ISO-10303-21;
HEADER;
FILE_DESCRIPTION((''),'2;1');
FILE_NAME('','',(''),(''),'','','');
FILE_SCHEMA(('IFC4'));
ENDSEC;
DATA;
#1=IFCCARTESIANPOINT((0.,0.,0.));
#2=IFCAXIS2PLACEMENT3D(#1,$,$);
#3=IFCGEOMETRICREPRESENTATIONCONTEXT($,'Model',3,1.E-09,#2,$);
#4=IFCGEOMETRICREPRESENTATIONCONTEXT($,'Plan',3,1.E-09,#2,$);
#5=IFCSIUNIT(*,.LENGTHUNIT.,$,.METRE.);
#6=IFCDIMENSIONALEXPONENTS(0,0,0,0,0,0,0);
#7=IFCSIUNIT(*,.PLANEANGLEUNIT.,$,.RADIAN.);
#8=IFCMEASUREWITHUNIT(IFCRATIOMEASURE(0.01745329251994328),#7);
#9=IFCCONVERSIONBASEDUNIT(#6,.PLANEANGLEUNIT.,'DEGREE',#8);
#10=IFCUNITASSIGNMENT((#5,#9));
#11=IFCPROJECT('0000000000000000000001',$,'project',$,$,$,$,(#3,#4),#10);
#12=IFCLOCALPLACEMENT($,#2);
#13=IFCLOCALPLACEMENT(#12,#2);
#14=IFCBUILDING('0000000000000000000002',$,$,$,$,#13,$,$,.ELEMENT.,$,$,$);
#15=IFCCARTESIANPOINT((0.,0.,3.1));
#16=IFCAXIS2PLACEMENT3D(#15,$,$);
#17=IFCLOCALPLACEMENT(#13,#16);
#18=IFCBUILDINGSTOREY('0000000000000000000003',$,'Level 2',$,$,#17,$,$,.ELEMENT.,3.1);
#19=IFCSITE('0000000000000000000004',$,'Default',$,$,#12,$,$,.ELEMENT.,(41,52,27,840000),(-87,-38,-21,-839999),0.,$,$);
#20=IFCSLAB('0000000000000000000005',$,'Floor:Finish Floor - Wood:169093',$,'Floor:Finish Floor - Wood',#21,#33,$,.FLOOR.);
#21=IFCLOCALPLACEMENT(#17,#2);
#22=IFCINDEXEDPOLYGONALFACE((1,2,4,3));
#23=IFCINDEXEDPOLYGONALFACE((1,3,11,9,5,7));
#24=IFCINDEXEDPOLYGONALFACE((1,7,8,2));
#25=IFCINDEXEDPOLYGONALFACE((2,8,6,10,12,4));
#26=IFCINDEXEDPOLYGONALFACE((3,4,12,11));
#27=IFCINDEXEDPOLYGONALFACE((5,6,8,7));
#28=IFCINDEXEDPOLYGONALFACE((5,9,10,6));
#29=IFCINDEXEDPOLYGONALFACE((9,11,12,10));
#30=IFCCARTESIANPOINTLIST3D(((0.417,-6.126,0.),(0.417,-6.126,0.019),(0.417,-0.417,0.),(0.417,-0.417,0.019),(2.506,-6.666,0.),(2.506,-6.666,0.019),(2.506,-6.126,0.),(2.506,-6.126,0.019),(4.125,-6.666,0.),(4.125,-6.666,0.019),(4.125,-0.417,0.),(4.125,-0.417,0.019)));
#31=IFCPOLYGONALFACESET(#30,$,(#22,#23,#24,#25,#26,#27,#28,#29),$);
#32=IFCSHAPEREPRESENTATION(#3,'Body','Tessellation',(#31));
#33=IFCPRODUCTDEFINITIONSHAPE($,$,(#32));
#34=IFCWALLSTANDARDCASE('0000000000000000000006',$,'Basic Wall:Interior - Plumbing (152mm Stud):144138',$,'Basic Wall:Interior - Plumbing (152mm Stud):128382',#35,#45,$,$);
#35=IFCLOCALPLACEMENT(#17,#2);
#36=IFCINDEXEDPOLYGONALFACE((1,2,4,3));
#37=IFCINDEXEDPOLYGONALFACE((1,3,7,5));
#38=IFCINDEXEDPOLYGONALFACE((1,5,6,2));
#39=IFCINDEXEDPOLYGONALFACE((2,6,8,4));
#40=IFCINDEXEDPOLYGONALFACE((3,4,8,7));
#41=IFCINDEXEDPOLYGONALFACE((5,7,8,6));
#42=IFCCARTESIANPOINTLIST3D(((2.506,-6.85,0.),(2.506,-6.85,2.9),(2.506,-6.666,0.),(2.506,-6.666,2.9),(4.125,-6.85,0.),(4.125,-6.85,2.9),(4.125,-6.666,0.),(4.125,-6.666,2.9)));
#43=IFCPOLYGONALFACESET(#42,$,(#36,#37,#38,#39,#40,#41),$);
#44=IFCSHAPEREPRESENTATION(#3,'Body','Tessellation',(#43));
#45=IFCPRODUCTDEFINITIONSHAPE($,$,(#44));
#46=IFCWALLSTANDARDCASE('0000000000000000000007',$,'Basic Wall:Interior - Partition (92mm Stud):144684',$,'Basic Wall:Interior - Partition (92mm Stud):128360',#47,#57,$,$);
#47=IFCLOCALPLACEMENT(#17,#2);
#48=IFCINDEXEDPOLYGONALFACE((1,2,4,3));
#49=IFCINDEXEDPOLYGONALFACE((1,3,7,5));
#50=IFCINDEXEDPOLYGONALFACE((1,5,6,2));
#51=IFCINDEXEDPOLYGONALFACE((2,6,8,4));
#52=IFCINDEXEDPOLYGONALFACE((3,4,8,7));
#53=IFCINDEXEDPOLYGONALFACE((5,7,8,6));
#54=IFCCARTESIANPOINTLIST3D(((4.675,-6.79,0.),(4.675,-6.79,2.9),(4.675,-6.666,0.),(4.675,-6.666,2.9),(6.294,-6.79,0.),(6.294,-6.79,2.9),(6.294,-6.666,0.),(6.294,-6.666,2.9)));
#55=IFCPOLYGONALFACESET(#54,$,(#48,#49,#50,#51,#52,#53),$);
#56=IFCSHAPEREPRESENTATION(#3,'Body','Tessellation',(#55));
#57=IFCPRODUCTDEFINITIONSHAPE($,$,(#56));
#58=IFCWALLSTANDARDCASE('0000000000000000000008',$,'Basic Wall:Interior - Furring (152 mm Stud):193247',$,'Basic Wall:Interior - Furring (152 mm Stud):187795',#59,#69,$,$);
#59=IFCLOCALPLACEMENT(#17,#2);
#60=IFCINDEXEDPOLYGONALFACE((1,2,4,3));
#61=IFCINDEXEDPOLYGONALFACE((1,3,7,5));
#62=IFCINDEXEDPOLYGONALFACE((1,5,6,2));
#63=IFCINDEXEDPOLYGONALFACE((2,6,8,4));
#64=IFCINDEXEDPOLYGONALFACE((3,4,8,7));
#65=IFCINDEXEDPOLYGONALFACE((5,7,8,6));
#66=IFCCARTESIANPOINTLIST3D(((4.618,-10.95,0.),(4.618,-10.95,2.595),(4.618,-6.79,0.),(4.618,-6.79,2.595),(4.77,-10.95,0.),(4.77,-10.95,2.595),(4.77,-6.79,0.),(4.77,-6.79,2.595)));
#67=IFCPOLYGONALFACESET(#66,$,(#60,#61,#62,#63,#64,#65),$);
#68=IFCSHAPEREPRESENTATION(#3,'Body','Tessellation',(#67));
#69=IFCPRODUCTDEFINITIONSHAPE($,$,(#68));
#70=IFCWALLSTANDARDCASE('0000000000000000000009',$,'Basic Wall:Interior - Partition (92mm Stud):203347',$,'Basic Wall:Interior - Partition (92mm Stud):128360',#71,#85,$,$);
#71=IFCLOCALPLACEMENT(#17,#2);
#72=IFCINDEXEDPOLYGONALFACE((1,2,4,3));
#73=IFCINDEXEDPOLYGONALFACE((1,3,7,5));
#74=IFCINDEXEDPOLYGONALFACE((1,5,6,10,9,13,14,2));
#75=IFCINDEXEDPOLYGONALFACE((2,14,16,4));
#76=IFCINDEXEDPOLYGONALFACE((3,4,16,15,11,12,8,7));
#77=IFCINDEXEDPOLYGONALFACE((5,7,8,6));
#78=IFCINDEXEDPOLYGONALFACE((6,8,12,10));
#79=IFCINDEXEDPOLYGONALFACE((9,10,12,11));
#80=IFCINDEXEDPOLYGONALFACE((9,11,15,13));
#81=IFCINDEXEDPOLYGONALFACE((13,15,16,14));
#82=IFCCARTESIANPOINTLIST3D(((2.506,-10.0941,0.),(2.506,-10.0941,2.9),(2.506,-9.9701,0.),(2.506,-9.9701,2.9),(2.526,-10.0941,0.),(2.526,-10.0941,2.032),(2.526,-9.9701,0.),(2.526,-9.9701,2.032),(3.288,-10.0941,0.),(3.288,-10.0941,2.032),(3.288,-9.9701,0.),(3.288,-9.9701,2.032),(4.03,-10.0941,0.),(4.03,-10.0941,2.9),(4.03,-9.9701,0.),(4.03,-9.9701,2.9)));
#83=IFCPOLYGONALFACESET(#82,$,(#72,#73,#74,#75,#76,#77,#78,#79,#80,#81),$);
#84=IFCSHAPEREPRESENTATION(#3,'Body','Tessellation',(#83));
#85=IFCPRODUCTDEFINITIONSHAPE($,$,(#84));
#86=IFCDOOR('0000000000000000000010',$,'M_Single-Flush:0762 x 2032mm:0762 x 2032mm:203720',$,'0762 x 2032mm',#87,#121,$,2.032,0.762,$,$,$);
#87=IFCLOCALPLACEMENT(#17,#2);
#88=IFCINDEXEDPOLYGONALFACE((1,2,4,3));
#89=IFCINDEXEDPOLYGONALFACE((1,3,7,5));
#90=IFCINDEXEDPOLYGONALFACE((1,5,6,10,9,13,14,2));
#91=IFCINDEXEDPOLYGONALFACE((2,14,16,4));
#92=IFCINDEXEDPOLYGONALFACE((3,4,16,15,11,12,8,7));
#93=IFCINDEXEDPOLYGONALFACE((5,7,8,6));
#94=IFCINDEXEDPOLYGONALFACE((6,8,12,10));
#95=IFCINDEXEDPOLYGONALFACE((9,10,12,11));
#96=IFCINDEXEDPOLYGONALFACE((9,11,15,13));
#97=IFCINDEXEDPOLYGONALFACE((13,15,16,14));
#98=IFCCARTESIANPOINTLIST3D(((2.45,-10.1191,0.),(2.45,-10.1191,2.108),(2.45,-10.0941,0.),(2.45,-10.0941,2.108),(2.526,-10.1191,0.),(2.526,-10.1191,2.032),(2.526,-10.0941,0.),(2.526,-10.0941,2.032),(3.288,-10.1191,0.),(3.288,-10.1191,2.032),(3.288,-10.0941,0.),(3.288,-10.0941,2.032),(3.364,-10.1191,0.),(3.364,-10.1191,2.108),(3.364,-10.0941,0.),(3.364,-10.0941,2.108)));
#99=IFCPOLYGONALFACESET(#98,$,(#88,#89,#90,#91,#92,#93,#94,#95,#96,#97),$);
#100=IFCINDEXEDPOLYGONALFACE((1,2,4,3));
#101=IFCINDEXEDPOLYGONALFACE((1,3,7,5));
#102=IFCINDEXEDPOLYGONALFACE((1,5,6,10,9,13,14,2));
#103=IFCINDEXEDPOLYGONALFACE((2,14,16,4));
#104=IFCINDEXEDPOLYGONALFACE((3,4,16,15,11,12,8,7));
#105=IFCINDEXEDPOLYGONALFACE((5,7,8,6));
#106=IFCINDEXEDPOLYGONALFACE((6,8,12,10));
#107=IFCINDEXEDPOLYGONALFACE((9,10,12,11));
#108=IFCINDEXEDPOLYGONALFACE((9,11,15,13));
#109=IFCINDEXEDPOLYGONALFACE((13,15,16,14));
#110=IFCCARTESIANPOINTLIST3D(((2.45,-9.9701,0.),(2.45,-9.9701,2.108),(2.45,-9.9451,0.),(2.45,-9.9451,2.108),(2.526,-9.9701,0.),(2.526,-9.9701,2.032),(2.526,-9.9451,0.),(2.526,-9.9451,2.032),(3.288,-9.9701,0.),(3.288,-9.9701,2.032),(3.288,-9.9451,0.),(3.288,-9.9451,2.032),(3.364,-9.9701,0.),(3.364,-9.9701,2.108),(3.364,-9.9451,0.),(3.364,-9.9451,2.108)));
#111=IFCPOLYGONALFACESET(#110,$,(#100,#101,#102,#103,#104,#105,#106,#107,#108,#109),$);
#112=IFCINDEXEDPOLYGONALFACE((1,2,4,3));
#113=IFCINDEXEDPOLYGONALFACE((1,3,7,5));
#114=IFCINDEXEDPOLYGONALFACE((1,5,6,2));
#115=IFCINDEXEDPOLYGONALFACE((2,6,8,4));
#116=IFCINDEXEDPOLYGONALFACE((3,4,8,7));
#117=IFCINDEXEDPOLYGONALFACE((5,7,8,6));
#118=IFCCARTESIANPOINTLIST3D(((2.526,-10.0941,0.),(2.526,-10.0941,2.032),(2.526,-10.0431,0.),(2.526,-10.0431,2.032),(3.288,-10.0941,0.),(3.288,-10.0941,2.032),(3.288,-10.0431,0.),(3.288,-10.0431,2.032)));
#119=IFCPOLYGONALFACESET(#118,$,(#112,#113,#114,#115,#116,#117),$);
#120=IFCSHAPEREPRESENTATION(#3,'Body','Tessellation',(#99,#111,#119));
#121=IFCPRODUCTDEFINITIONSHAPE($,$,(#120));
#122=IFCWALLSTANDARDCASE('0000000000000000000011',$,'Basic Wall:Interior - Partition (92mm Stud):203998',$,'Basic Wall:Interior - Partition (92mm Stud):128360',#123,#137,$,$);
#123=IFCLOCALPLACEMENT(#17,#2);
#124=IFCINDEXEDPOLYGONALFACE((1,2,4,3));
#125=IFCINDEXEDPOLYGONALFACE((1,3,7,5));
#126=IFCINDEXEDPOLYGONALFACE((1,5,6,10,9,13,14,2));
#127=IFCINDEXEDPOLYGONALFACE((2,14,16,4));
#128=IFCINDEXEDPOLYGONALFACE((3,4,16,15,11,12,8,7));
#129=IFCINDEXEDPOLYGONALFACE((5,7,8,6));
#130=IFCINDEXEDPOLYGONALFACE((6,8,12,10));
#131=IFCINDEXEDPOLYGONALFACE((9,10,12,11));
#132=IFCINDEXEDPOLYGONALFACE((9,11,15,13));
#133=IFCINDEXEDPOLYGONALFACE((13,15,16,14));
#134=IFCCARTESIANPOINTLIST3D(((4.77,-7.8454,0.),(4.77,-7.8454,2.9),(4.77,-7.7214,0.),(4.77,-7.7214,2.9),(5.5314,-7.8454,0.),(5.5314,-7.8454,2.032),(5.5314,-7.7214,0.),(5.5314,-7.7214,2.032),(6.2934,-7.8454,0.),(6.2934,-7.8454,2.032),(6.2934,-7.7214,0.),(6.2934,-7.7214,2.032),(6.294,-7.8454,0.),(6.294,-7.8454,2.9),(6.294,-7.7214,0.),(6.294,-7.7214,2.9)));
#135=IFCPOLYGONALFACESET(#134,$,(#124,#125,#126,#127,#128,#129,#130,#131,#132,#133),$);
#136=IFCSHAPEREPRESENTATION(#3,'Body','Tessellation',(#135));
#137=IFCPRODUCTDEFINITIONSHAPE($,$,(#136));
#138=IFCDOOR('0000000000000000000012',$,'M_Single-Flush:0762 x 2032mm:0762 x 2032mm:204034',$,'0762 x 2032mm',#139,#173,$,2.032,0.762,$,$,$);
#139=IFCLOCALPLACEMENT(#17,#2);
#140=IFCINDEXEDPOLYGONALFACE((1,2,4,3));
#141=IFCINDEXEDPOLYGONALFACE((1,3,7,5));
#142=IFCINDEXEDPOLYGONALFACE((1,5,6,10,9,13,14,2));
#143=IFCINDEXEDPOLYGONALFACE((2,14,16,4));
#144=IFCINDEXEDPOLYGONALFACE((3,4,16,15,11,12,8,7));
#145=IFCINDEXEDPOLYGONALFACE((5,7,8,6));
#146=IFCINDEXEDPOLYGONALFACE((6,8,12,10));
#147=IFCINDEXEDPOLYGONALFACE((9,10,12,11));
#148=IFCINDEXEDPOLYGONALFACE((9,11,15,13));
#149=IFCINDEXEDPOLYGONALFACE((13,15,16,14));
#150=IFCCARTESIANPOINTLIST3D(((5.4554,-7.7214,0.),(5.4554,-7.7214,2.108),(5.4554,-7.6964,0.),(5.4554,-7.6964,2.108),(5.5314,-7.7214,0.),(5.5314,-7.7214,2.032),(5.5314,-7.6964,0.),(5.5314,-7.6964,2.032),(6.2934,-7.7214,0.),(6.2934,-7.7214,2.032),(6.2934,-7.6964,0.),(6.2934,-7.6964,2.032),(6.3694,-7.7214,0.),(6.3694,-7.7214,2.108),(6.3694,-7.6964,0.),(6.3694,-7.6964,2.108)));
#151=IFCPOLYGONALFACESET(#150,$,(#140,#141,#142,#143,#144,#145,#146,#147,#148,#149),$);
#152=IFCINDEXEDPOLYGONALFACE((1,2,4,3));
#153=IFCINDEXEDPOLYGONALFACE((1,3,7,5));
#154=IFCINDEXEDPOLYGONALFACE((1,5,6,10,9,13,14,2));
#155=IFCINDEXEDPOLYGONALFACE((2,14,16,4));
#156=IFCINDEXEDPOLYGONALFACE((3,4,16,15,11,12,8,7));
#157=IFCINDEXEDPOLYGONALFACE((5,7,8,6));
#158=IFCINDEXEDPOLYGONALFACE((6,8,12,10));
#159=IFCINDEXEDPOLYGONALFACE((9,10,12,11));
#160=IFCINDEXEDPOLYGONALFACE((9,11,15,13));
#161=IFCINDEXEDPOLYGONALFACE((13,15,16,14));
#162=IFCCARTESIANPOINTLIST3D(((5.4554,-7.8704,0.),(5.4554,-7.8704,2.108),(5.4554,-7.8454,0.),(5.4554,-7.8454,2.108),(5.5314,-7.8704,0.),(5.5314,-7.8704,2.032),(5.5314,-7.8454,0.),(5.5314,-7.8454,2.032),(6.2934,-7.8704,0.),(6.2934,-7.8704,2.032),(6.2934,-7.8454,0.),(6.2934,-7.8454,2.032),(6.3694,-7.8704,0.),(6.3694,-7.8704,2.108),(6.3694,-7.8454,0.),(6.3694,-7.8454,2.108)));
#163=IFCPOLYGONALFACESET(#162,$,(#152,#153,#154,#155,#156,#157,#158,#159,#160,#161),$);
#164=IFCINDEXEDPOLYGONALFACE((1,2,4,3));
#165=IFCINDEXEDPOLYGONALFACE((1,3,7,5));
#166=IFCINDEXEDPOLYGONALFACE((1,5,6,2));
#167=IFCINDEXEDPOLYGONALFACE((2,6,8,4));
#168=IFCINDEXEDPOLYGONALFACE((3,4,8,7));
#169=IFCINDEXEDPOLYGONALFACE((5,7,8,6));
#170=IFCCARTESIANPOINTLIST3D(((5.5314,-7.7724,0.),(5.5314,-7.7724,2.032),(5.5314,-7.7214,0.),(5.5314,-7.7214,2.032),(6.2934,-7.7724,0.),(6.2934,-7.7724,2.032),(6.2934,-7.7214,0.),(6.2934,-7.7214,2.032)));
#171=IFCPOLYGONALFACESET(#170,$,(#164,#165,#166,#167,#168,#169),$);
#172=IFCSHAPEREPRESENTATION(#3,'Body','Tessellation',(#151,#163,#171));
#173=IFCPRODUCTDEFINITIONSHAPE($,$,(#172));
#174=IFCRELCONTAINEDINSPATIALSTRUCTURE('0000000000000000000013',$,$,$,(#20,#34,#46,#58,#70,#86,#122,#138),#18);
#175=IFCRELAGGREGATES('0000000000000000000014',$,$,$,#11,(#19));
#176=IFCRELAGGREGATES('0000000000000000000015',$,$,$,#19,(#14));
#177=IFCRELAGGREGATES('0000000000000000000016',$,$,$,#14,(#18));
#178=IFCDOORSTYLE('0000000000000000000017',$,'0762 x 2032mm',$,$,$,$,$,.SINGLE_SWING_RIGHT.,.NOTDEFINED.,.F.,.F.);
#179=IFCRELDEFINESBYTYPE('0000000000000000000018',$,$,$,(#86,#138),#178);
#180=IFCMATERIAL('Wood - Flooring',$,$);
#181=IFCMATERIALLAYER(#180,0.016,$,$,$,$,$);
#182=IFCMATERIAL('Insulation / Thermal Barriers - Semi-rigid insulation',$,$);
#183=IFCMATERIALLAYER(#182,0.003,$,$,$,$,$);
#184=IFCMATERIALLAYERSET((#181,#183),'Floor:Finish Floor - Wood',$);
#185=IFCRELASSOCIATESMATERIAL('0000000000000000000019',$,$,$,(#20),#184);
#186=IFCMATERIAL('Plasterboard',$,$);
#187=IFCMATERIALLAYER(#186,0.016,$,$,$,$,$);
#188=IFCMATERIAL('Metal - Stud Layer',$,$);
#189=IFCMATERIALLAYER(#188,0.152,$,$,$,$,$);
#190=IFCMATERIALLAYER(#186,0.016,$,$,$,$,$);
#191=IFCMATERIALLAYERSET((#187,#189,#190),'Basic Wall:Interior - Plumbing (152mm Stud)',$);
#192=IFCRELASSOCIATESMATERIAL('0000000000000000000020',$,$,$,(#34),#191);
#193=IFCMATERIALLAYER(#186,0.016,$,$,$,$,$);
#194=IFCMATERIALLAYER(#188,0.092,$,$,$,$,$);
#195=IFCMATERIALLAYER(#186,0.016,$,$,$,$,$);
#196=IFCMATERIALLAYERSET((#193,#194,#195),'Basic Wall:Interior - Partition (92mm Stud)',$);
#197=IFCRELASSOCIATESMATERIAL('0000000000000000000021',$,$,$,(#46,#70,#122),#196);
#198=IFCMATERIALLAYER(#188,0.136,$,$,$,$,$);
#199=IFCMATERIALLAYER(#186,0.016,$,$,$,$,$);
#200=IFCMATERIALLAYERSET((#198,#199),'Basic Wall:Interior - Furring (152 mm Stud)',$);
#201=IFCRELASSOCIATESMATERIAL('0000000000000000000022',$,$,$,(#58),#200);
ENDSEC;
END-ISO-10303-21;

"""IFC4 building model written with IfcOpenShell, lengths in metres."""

from ifc_helpers import new_model, entity, si_unit, converted_unit, frame, frame_2d, origin, origin_2d_with_axis, place, context, project, spatial, polyline, rectangle, outline, extrude, source, transform, mapped, material, layer, layer_set, layer_usage, type_object, type_shapes, element, fill, save


model = new_model("IFC4")

# Units and contexts
model_context = context("Model", 3, precision=1e-09, world=origin())
plan_context = context("Plan", 3, precision=1e-09, world=origin())
ifc_project = project(units=[si_unit("LENGTHUNIT", "METRE"), converted_unit("PLANEANGLEUNIT", "DEGREE", entity("IfcRatioMeasure", 0.01745329251994328), si_unit("PLANEANGLEUNIT", "RADIAN"), dimensions=[0, 0, 0, 0, 0, 0, 0])], contexts=[model_context, plan_context])

# Site, building, storey
site_placement = place(None, origin())
site = spatial("IfcSite", under=ifc_project, at=site_placement, Name="Default", CompositionType="ELEMENT", RefLatitude=(41, 52, 27, 840000), RefLongitude=(-87, -38, -21, -839999), RefElevation=0.0)
building_placement = place(site_placement, origin())
building = spatial("IfcBuilding", under=site, at=building_placement, CompositionType="ELEMENT")
storey_placement = place(building_placement, frame((0.0, 0.0, 3.1)))
storey = spatial("IfcBuildingStorey", under=building, at=storey_placement, Name="Level 2", CompositionType="ELEMENT", Elevation=3.1)

# Slab
ifc_material_1 = material(Name="Wood - Flooring")
ifc_layer_1 = layer(ifc_material_1, 0.016)
ifc_material_2 = material(Name="Insulation / Thermal Barriers - Semi-rigid insulation")
ifc_layer_2 = layer(ifc_material_2, 0.003)
ifc_layer_set_1 = layer_set([ifc_layer_1, ifc_layer_2], Name="Floor:Finish Floor - Wood")
ifc_layer_usage_1 = layer_usage(ifc_layer_set_1, "AXIS3", "POSITIVE", 0.0)
slab_placement = place(storey_placement, frame((0.417, -6.666, 0.0)))
element("IfcSlab", 1, at=slab_placement, inside=storey, material=ifc_layer_usage_1, Name="Floor:Finish Floor - Wood:169093", ObjectType="Floor:Finish Floor - Wood", PredefinedType="FLOOR", context=model_context, shape_type="SweptSolid", body=[
    extrude(outline(polyline([(1.854, 3.1245), (-1.854, 3.1245), (-1.854, -3.1245), (-0.235, -3.1245), (-0.235, -2.5845), (1.854, -2.5845), (1.854, 3.1245)])), frame((1.854, 3.1245, 0.019), z_axis=(0.0, 0.0, -1.0), x_axis=(-1.0, 0.0, 0.0)), (0.0, 0.0, 1.0), 0.019),
])

# Walls
ifc_material_3 = material(Name="Plasterboard")
ifc_layer_3 = layer(ifc_material_3, 0.016)
ifc_material_4 = material(Name="Metal - Stud Layer")
ifc_layer_4 = layer(ifc_material_4, 0.152)
ifc_layer_5 = layer(ifc_material_3, 0.016)
ifc_layer_set_2 = layer_set([ifc_layer_3, ifc_layer_4, ifc_layer_5], Name="Basic Wall:Interior - Plumbing (152mm Stud)")
ifc_layer_usage_2 = layer_usage(ifc_layer_set_2, "AXIS2", "NEGATIVE", 0.092)
wall_1_placement = place(storey_placement, frame((2.506, -6.758, 0.0)))
element("IfcWallStandardCase", 2, at=wall_1_placement, inside=storey, material=ifc_layer_usage_2, Name="Basic Wall:Interior - Plumbing (152mm Stud):144138", ObjectType="Basic Wall:Interior - Plumbing (152mm Stud):128382", context=model_context, shape_type="SweptSolid", body=[
    extrude(rectangle(XDim=1.619, YDim=0.184, at=frame_2d((0.8095, 0.0), x_axis=(-1.0, 0.0))), origin(), (0.0, 0.0, 1.0), 2.9),
])
ifc_layer_6 = layer(ifc_material_3, 0.016)
ifc_layer_7 = layer(ifc_material_4, 0.092)
ifc_layer_8 = layer(ifc_material_3, 0.016)
ifc_layer_set_3 = layer_set([ifc_layer_6, ifc_layer_7, ifc_layer_8], Name="Basic Wall:Interior - Partition (92mm Stud)")
ifc_layer_usage_3 = layer_usage(ifc_layer_set_3, "AXIS2", "NEGATIVE", 0.062)
wall_2_placement = place(storey_placement, frame((4.675, -6.728, 0.0)))
element("IfcWallStandardCase", 3, at=wall_2_placement, inside=storey, material=ifc_layer_usage_3, Name="Basic Wall:Interior - Partition (92mm Stud):144684", ObjectType="Basic Wall:Interior - Partition (92mm Stud):128360", context=model_context, shape_type="SweptSolid", body=[
    extrude(rectangle(XDim=1.619, YDim=0.124, at=frame_2d((0.8095, 0.0), x_axis=(-1.0, 0.0))), origin(), (0.0, 0.0, 1.0), 2.9),
])
ifc_layer_9 = layer(ifc_material_4, 0.136)
ifc_layer_10 = layer(ifc_material_3, 0.016)
ifc_layer_set_4 = layer_set([ifc_layer_9, ifc_layer_10], Name="Basic Wall:Interior - Furring (152 mm Stud)")
ifc_layer_usage_4 = layer_usage(ifc_layer_set_4, "AXIS2", "POSITIVE", -0.076)
wall_3_placement = place(storey_placement, frame((4.694, -6.79, 0.0), z_axis=(0.0, 0.0, 1.0), x_axis=(0.0, -1.0, 0.0)))
element("IfcWallStandardCase", 4, at=wall_3_placement, inside=storey, material=ifc_layer_usage_4, Name="Basic Wall:Interior - Furring (152 mm Stud):193247", ObjectType="Basic Wall:Interior - Furring (152 mm Stud):187795", context=model_context, shape_type="SweptSolid", body=[
    extrude(rectangle(XDim=4.16, YDim=0.152, at=frame_2d((2.08, 0.0), x_axis=(-1.0, 0.0))), origin(), (0.0, 0.0, 1.0), 2.595),
])

# Walls, openings, doors
ifc_layer_usage_5 = layer_usage(ifc_layer_set_3, "AXIS2", "NEGATIVE", 0.062)
wall_4_placement = place(storey_placement, frame((4.03, -10.0321, 0.0), z_axis=(0.0, 0.0, 1.0), x_axis=(-1.0, 0.0, 0.0)))
wall_4 = element("IfcWallStandardCase", 5, at=wall_4_placement, inside=storey, material=ifc_layer_usage_5, Name="Basic Wall:Interior - Partition (92mm Stud):203347", ObjectType="Basic Wall:Interior - Partition (92mm Stud):128360", context=model_context, shape_type="SweptSolid", body=[
    extrude(rectangle(XDim=1.524, YDim=0.124, at=frame_2d((0.762, 0.0), x_axis=(-1.0, 0.0))), origin(), (0.0, 0.0, 1.0), 2.9),
])
opening_1_placement = place(wall_4_placement, frame((0.742, -0.062, 0.0)))
opening_1 = element("IfcOpeningElement", 6, at=opening_1_placement, cuts=wall_4, ObjectType="Opening", context=model_context, shape_type="SweptSolid", body=[
    extrude(rectangle(XDim=0.762, YDim=2.032, at=frame_2d((1.016, 0.381), x_axis=(0.0, 1.0))), frame((0.0, 0.0, 0.0), z_axis=(0.0, 1.0, 0.0), x_axis=(0.0, 0.0, 1.0)), (0.0, 0.0, 1.0), 0.124),
])
door_style = type_object("IfcDoorStyle", Name="0762 x 2032mm", ConstructionType="NOTDEFINED", OperationType="SINGLE_SWING_RIGHT", ParameterTakesPrecedence=False, Sizeable=False)
shared_shape = source(origin(), model_context, "Body", "SweptSolid", [
    extrude(outline(polyline([(-0.457, -1.073), (0.457, -1.073), (0.457, 1.035), (0.381, 1.035), (0.381, -0.997), (-0.381, -0.997), (-0.381, 1.035), (-0.457, 1.035), (-0.457, -1.073)])), frame((0.381, 0.124, 1.035), z_axis=(0.0, 1.0, 0.0), x_axis=(1.0, 0.0, 0.0)), (0.0, 0.0, 1.0), 0.025),
    extrude(outline(polyline([(-1.073, -0.457), (1.035, -0.457), (1.035, -0.381), (-0.997, -0.381), (-0.997, 0.381), (1.035, 0.381), (1.035, 0.457), (-1.073, 0.457), (-1.073, -0.457)])), frame((0.381, -0.025, 1.035), z_axis=(0.0, 1.0, 0.0), x_axis=(0.0, 0.0, -1.0)), (0.0, 0.0, 1.0), 0.025),
    extrude(rectangle(XDim=0.051, YDim=0.762, at=origin_2d_with_axis()), frame((0.381, 0.0985, 0.0), z_axis=(0.0, 0.0, 1.0), x_axis=(0.0, 1.0, 0.0)), (0.0, 0.0, 1.0), 2.032),
])
type_shapes(door_style, [shared_shape])
door_1_placement = place(opening_1_placement, origin())
door_1 = element("IfcDoor", 7, at=door_1_placement, inside=storey, type_object=door_style, Name="M_Single-Flush:0762 x 2032mm:0762 x 2032mm:203720", ObjectType="0762 x 2032mm", OverallHeight=2.032, OverallWidth=0.762, context=model_context, shape_type="MappedRepresentation", body=[
    mapped(shared_shape, transform((0.0, 0.0, 0.0), scale=1.0)),
])
fill(opening_1, door_1)
ifc_layer_usage_6 = layer_usage(ifc_layer_set_3, "AXIS2", "POSITIVE", -0.062)
wall_5_placement = place(storey_placement, frame((4.77, -7.7834, 0.0)))
wall_5 = element("IfcWallStandardCase", 8, at=wall_5_placement, inside=storey, material=ifc_layer_usage_6, Name="Basic Wall:Interior - Partition (92mm Stud):203998", ObjectType="Basic Wall:Interior - Partition (92mm Stud):128360", context=model_context, shape_type="SweptSolid", body=[
    extrude(rectangle(XDim=1.524, YDim=0.124, at=frame_2d((0.762, 0.0), x_axis=(-1.0, 0.0))), origin(), (0.0, 0.0, 1.0), 2.9),
])
opening_2_placement = place(wall_5_placement, frame((0.7614, -0.062, 0.0)))
opening_2 = element("IfcOpeningElement", 9, at=opening_2_placement, cuts=wall_5, ObjectType="Opening", context=model_context, shape_type="SweptSolid", body=[
    extrude(rectangle(XDim=0.762, YDim=2.032, at=frame_2d((1.016, 0.381), x_axis=(0.0, 1.0))), frame((0.0, 0.0, 0.0), z_axis=(0.0, 1.0, 0.0), x_axis=(0.0, 0.0, 1.0)), (0.0, 0.0, 1.0), 0.124),
])
door_2_placement = place(opening_2_placement, origin())
door_2 = element("IfcDoor", 10, at=door_2_placement, inside=storey, type_object=door_style, Name="M_Single-Flush:0762 x 2032mm:0762 x 2032mm:204034", ObjectType="0762 x 2032mm", OverallHeight=2.032, OverallWidth=0.762, context=model_context, shape_type="MappedRepresentation", body=[
    mapped(shared_shape, transform((0.0, 0.0, 0.0), scale=1.0)),
])
fill(opening_2, door_2)

save(model, "model.ifc")
